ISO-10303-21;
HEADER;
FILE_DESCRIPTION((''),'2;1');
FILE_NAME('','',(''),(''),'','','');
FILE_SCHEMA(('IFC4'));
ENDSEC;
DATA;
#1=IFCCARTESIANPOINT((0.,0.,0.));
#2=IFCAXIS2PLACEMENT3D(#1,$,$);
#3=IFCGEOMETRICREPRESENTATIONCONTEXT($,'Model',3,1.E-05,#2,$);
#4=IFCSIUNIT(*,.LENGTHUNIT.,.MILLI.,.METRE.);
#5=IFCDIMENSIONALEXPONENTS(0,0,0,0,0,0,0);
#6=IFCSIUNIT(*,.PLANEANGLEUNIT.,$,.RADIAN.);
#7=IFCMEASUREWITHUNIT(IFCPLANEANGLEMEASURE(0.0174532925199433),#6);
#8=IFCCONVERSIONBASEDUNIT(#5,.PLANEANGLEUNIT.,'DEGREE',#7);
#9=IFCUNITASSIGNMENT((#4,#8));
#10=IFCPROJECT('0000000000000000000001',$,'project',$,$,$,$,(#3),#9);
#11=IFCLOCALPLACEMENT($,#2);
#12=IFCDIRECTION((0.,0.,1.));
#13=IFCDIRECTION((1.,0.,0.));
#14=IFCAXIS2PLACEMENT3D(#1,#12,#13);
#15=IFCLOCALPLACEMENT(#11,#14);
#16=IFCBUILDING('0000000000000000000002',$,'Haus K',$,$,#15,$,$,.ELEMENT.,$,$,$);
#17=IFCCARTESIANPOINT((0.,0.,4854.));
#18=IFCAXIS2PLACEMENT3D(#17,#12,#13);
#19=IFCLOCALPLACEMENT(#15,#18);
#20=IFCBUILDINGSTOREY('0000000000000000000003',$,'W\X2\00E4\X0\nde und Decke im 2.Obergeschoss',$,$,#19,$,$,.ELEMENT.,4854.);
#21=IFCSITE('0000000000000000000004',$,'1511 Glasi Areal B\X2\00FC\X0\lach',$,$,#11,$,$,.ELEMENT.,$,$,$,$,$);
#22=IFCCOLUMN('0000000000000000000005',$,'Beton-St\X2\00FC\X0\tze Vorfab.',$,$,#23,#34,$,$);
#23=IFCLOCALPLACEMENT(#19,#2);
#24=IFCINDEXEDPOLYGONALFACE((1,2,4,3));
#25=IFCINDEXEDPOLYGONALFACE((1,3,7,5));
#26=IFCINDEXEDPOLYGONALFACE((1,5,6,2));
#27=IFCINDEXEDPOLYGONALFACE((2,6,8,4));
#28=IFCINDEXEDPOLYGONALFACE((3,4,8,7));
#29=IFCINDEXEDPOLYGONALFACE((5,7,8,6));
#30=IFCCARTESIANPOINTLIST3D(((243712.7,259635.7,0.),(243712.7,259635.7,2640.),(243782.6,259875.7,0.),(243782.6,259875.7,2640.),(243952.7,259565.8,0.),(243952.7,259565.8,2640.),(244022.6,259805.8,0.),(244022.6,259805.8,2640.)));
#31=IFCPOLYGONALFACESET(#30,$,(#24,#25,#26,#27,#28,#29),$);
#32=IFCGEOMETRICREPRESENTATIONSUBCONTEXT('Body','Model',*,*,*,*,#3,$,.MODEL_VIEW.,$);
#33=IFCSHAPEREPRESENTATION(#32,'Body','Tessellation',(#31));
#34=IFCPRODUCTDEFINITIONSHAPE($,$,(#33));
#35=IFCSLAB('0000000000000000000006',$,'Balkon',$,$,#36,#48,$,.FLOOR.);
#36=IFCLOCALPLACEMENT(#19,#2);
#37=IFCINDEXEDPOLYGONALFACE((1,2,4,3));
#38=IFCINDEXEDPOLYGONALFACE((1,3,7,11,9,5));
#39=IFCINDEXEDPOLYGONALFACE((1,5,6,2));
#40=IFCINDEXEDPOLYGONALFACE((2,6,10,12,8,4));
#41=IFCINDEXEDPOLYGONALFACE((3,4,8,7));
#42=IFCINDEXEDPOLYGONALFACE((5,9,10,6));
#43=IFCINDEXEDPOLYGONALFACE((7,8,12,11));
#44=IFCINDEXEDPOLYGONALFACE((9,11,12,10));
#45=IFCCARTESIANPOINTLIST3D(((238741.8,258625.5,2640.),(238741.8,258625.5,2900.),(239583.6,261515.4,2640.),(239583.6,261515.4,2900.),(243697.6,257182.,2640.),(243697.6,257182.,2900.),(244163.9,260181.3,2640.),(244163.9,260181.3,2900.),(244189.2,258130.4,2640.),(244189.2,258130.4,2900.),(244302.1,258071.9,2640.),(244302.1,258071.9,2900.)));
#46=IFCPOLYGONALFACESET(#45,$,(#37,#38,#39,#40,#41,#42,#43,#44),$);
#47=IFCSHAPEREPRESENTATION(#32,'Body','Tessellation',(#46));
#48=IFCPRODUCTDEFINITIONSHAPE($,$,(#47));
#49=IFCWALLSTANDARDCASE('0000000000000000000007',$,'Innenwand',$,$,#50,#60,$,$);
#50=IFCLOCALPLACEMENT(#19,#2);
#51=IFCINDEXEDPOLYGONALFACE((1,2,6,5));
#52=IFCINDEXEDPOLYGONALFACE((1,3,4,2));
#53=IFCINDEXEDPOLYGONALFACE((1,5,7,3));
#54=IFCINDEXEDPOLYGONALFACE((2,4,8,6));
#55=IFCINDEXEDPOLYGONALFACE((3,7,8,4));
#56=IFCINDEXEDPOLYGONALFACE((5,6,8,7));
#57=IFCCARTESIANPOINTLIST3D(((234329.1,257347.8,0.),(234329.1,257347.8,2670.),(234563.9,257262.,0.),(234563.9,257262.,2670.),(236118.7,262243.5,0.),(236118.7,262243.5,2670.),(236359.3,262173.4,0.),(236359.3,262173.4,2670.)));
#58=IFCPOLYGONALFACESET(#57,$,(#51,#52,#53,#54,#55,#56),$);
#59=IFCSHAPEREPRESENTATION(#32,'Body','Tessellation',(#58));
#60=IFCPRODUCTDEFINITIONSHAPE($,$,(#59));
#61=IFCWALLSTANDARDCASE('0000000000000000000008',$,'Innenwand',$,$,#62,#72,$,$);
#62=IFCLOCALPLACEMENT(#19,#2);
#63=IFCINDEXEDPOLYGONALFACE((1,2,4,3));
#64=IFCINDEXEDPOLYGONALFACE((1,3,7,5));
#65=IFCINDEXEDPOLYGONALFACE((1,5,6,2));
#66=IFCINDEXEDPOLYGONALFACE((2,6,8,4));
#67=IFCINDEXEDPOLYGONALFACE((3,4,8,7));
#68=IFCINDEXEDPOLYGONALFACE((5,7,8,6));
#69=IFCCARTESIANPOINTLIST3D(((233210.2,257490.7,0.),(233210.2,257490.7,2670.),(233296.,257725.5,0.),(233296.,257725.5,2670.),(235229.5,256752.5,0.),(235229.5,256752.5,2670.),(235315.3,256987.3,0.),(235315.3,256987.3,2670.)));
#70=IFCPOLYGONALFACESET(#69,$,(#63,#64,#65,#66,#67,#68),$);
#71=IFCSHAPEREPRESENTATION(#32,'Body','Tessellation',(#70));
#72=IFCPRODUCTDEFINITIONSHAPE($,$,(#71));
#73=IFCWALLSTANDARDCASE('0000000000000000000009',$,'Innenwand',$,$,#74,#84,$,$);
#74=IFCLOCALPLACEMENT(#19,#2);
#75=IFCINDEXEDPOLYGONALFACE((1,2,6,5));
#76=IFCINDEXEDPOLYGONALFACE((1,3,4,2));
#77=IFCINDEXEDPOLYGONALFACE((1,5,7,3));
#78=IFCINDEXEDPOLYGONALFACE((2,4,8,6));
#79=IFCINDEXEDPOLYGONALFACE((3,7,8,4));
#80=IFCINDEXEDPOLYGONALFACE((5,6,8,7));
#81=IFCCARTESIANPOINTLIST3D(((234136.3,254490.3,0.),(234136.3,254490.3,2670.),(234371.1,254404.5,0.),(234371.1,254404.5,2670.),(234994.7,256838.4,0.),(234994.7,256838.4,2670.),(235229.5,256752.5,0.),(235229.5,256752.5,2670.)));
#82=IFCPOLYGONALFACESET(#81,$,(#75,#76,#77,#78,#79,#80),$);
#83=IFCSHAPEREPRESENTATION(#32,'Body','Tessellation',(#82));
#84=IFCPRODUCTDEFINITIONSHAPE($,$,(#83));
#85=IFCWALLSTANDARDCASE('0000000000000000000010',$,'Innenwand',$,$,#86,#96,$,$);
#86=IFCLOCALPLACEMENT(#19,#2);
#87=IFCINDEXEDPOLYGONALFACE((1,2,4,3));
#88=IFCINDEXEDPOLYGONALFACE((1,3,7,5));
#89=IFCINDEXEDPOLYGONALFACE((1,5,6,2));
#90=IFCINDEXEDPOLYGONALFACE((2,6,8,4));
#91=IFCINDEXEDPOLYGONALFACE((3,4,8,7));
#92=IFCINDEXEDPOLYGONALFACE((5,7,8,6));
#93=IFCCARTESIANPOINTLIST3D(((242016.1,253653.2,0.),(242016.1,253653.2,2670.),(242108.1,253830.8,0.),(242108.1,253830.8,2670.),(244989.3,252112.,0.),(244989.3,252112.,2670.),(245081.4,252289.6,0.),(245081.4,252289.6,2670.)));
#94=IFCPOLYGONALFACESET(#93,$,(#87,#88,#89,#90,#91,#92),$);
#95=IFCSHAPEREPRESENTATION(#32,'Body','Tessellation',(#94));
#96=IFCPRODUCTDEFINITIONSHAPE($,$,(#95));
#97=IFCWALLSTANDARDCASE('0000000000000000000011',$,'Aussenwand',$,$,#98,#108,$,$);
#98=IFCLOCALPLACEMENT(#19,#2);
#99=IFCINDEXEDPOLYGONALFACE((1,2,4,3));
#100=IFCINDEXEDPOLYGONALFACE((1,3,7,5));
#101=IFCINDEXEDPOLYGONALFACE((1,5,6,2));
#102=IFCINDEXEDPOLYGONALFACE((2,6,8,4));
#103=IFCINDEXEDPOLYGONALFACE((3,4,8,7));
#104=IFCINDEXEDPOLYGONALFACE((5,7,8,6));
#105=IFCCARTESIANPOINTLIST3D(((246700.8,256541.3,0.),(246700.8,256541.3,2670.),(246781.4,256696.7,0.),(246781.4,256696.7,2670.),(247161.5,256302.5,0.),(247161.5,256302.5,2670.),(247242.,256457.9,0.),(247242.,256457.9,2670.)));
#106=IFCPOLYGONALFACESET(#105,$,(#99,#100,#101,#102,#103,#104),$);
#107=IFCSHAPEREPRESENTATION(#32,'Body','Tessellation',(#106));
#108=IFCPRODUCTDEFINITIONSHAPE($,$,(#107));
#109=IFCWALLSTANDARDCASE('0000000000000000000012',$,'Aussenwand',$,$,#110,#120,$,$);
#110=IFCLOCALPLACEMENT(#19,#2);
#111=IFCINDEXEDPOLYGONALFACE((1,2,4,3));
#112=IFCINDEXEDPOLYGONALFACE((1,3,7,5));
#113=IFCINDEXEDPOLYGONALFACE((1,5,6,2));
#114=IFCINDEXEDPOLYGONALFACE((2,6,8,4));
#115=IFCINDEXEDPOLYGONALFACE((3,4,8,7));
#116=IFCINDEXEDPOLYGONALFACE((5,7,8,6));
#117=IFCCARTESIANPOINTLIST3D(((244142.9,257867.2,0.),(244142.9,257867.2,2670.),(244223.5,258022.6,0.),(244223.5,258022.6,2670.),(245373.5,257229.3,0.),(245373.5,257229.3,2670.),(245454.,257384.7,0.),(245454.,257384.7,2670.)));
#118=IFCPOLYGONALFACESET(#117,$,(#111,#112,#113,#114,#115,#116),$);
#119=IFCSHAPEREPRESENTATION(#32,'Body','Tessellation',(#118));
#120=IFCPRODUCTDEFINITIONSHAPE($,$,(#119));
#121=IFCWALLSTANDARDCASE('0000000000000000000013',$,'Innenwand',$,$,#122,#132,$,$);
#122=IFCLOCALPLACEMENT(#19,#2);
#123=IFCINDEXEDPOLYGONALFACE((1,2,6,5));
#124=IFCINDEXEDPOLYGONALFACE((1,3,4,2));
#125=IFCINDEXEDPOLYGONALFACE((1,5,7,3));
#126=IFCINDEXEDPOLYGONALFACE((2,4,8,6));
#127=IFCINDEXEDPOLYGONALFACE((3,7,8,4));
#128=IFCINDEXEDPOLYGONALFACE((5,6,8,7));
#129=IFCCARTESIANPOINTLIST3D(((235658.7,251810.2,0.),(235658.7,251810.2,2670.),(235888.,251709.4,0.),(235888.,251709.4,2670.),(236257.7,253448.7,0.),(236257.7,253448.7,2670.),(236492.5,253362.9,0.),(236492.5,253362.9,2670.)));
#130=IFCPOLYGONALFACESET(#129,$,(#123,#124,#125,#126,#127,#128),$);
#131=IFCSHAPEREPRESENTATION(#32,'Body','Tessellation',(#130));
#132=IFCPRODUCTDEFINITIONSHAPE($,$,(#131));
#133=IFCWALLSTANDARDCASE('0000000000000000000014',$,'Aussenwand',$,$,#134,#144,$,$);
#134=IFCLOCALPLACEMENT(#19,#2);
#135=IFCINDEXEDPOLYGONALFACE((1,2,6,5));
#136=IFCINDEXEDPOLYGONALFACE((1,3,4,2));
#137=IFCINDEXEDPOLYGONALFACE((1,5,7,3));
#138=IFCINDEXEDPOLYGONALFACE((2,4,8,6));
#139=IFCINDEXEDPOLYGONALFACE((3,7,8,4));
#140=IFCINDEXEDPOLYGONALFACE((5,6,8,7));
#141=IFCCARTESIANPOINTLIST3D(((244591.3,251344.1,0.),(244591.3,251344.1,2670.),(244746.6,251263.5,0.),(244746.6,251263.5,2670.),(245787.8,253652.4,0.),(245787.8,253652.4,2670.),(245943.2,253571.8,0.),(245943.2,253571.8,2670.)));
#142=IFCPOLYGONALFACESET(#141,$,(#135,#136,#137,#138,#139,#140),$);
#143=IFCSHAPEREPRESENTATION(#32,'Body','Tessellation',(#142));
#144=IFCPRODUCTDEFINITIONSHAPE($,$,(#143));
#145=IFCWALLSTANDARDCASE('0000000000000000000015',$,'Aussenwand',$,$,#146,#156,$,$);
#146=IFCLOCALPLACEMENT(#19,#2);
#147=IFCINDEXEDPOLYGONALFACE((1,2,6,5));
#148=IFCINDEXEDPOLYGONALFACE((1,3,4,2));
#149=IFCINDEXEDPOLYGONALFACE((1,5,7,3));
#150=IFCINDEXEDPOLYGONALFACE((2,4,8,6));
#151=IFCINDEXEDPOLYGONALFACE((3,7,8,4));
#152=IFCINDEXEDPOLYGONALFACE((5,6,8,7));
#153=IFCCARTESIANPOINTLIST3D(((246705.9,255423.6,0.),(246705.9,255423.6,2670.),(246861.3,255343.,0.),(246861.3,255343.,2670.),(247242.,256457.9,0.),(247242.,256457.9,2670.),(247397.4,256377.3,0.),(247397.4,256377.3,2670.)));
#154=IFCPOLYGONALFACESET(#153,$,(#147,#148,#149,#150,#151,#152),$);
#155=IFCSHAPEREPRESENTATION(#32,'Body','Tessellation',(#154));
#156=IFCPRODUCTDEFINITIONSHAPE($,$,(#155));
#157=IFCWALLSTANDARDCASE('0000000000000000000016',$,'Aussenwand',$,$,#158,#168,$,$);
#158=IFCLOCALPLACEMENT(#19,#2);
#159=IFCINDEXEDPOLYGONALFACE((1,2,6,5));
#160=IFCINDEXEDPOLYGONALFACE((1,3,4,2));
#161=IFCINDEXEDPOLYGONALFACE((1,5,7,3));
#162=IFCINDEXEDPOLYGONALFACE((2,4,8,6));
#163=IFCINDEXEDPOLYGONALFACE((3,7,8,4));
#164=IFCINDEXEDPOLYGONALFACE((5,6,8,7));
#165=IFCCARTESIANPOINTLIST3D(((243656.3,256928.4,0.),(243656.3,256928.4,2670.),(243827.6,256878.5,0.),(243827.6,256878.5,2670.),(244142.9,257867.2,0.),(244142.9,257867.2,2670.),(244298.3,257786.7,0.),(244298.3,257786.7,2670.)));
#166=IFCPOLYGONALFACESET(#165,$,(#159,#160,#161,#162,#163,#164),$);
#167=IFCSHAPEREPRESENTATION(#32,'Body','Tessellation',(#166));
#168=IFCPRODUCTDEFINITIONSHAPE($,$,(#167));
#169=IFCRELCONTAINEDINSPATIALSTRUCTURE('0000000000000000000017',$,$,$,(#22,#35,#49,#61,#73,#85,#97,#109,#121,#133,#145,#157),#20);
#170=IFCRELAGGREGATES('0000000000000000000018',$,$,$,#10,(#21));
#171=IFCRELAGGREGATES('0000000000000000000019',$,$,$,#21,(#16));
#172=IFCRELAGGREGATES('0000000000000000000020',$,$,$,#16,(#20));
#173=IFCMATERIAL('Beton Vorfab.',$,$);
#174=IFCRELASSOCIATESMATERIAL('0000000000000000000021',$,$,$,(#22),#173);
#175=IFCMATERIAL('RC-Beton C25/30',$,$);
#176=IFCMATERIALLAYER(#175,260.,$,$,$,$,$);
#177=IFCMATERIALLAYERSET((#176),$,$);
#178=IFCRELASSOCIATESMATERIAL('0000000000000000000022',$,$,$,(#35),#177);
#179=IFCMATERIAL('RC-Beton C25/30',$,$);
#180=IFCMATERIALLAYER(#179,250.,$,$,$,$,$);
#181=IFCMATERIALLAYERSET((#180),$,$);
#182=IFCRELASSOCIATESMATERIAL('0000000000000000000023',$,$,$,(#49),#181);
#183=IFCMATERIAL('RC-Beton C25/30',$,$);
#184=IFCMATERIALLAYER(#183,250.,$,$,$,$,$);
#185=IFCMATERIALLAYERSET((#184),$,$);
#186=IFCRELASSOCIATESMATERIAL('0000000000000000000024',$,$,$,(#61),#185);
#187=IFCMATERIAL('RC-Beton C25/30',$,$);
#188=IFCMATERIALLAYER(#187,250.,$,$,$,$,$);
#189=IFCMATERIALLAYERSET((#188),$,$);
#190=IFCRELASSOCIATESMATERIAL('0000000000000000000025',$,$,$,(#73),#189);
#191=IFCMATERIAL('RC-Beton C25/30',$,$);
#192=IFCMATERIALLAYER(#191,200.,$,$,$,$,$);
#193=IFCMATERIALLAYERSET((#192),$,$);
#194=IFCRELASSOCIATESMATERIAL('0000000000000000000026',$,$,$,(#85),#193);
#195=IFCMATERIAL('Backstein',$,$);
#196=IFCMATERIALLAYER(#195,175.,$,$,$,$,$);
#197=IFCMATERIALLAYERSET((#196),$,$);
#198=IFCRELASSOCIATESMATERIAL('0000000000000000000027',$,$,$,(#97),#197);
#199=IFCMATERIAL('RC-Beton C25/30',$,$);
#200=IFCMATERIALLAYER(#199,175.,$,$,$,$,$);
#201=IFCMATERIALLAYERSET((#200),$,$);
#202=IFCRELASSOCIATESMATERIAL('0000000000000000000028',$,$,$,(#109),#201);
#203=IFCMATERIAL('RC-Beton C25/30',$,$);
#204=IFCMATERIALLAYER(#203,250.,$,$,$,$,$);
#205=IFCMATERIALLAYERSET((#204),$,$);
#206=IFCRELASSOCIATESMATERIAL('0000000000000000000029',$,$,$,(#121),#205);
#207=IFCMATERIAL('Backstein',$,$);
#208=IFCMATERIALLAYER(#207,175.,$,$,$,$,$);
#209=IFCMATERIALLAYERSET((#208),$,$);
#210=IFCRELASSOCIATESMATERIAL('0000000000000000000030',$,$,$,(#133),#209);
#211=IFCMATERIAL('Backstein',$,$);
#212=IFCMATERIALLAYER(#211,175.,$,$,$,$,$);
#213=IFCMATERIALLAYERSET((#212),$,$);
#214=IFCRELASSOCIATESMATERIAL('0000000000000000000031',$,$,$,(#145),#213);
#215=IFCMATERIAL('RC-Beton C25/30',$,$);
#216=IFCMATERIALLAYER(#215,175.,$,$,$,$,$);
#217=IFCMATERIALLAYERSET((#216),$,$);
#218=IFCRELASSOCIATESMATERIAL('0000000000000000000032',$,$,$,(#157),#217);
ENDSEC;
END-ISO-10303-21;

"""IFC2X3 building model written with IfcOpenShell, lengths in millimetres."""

from ifc_helpers import new_model, entity, si_unit, converted_unit, frame, frame_2d, origin, origin_with_axes, place, context, subcontext, project, spatial, polyline, rectangle, outline, extrude, material, layer, layer_set, layer_usage, element, save


model = new_model("IFC2X3")

# Units and contexts
model_context = context("Model", 3, precision=1e-05, world=origin())
body_context = subcontext(model_context, "Body", "Model", "MODEL_VIEW")
ifc_project = project(units=[si_unit("LENGTHUNIT", "METRE", prefix="MILLI"), converted_unit("PLANEANGLEUNIT", "DEGREE", entity("IfcPlaneAngleMeasure", 0.0174532925199433), si_unit("PLANEANGLEUNIT", "RADIAN"), dimensions=[0, 0, 0, 0, 0, 0, 0])], contexts=[model_context])

# Site, building, storey
site_placement = place(None, origin())
site = spatial("IfcSite", under=ifc_project, at=site_placement, Name="1511 Glasi Areal Bülach", CompositionType="ELEMENT")
building_placement = place(site_placement, origin_with_axes())
building = spatial("IfcBuilding", under=site, at=building_placement, Name="Haus K", CompositionType="ELEMENT")
storey_placement = place(building_placement, frame((0.0, 0.0, 4854.0), z_axis=(0.0, 0.0, 1.0), x_axis=(1.0, 0.0, 0.0)))
storey = spatial("IfcBuildingStorey", under=building, at=storey_placement, Name="Wände und Decke im 2.Obergeschoss", CompositionType="ELEMENT", Elevation=4854.0)

# Column
ifc_material_1 = material(Name="Beton Vorfab.")
column_placement = place(storey_placement, frame((243712.7, 259635.7, 0.0), z_axis=(0.0, 0.0, 1.0), x_axis=(1.0, 0.0, 0.0)))
element("IfcColumn", 1, at=column_placement, inside=storey, material=ifc_material_1, Name="Beton-Stütze Vorfab.", context=body_context, shape_type="SweptSolid", body=[
    extrude(rectangle(XDim=250.0, YDim=250.0, at=frame_2d((155.0, 85.1), x_axis=(0.960099, -0.279661))), origin_with_axes(), (0.0, 0.0, 1.0), 2640.0),
])

# Slab
ifc_material_2 = material(Name="RC-Beton C25/30")
ifc_layer_1 = layer(ifc_material_2, 260.0)
ifc_layer_set_1 = layer_set([ifc_layer_1])
ifc_layer_usage_1 = layer_usage(ifc_layer_set_1, "AXIS3", "POSITIVE", 0.0)
slab_placement = place(storey_placement, frame((238741.8, 257182.0, 2640.0), z_axis=(0.0, 0.0, 1.0), x_axis=(1.0, 0.0, 0.0)))
element("IfcSlab", 2, at=slab_placement, inside=storey, material=ifc_layer_usage_1, Name="Balkon", PredefinedType="FLOOR", context=body_context, shape_type="SweptSolid", body=[
    extrude(outline(polyline([(841.8, 4333.4), (0.0, 1443.5), (4955.8, 0.0), (5447.4, 948.4), (5560.3, 889.9), (5422.0, 2999.3), (841.8, 4333.4)])), origin_with_axes(), (0.0, 0.0, 1.0), 260.0),
])

# Walls
ifc_material_3 = material(Name="RC-Beton C25/30")
ifc_layer_2 = layer(ifc_material_3, 250.0)
ifc_layer_set_2 = layer_set([ifc_layer_2])
ifc_layer_usage_2 = layer_usage(ifc_layer_set_2, "AXIS2", "POSITIVE", 0.0)
wall_1_placement = place(storey_placement, frame((234563.9, 257262.0, 0.0), z_axis=(0.0, 0.0, 1.0), x_axis=(0.343332, 0.939214, 0.0)))
element("IfcWallStandardCase", 3, at=wall_1_placement, inside=storey, material=ifc_layer_usage_2, Name="Innenwand", context=body_context, shape_type="SweptSolid", body=[
    extrude(outline(polyline([(0.0, 0.0), (5229.2, 0.0), (5212.5, 250.0), (0.0, 250.0), (0.0, 0.0)])), origin_with_axes(), (0.0, 0.0, 1.0), 2670.0),
])
ifc_material_4 = material(Name="RC-Beton C25/30")
ifc_layer_3 = layer(ifc_material_4, 250.0)
ifc_layer_set_3 = layer_set([ifc_layer_3])
ifc_layer_usage_3 = layer_usage(ifc_layer_set_3, "AXIS2", "POSITIVE", 0.0)
wall_2_placement = place(storey_placement, frame((235315.3, 256987.3, 0.0), z_axis=(0.0, 0.0, 1.0), x_axis=(-0.939214, 0.343332, 0.0)))
element("IfcWallStandardCase", 4, at=wall_2_placement, inside=storey, material=ifc_layer_usage_3, Name="Innenwand", context=body_context, shape_type="SweptSolid", body=[
    extrude(rectangle(XDim=2150.0, YDim=250.0, at=frame_2d((1075.0, 125.0), x_axis=(1.0, 0.0))), origin_with_axes(), (0.0, 0.0, 1.0), 2670.0),
])
ifc_material_5 = material(Name="RC-Beton C25/30")
ifc_layer_4 = layer(ifc_material_5, 250.0)
ifc_layer_set_4 = layer_set([ifc_layer_4])
ifc_layer_usage_4 = layer_usage(ifc_layer_set_4, "AXIS2", "POSITIVE", 0.0)
wall_3_placement = place(storey_placement, frame((234371.1, 254404.5, 0.0), z_axis=(0.0, 0.0, 1.0), x_axis=(0.343332, 0.939214, 0.0)))
element("IfcWallStandardCase", 5, at=wall_3_placement, inside=storey, material=ifc_layer_usage_4, Name="Innenwand", context=body_context, shape_type="SweptSolid", body=[
    extrude(rectangle(XDim=2500.0, YDim=250.0, at=frame_2d((1250.0, 125.0), x_axis=(1.0, 0.0))), origin_with_axes(), (0.0, 0.0, 1.0), 2670.0),
])
ifc_material_6 = material(Name="RC-Beton C25/30")
ifc_layer_5 = layer(ifc_material_6, 200.0)
ifc_layer_set_5 = layer_set([ifc_layer_5])
ifc_layer_usage_5 = layer_usage(ifc_layer_set_5, "AXIS2", "POSITIVE", 0.0)
wall_4_placement = place(storey_placement, frame((245081.4, 252289.6, 0.0), z_axis=(0.0, 0.0, 1.0), x_axis=(-0.887815, 0.4602, 0.0)))
element("IfcWallStandardCase", 6, at=wall_4_placement, inside=storey, material=ifc_layer_usage_5, Name="Innenwand", context=body_context, shape_type="SweptSolid", body=[
    extrude(rectangle(XDim=3349.0, YDim=200.0, at=frame_2d((1674.5, 100.0), x_axis=(1.0, 0.0))), origin_with_axes(), (0.0, 0.0, 1.0), 2670.0),
])
ifc_material_7 = material(Name="Backstein")
ifc_layer_6 = layer(ifc_material_7, 175.0)
ifc_layer_set_6 = layer_set([ifc_layer_6])
ifc_layer_usage_6 = layer_usage(ifc_layer_set_6, "AXIS2", "POSITIVE", 0.0)
wall_5_placement = place(storey_placement, frame((247242.0, 256457.9, 0.0), z_axis=(0.0, 0.0, 1.0), x_axis=(-0.887815, 0.4602, 0.0)))
element("IfcWallStandardCase", 7, at=wall_5_placement, inside=storey, material=ifc_layer_usage_6, Name="Aussenwand", context=body_context, shape_type="SweptSolid", body=[
    extrude(outline(polyline([(0.0, 0.0), (518.9, 0.0), (518.9, 175.0), (0.0, 175.0), (0.0, 0.0)])), origin_with_axes(), (0.0, 0.0, 1.0), 2670.0),
])
ifc_material_8 = material(Name="RC-Beton C25/30")
ifc_layer_7 = layer(ifc_material_8, 175.0)
ifc_layer_set_7 = layer_set([ifc_layer_7])
ifc_layer_usage_7 = layer_usage(ifc_layer_set_7, "AXIS2", "POSITIVE", 0.0)
wall_6_placement = place(storey_placement, frame((245454.0, 257384.7, 0.0), z_axis=(0.0, 0.0, 1.0), x_axis=(-0.887815, 0.4602, 0.0)))
element("IfcWallStandardCase", 8, at=wall_6_placement, inside=storey, material=ifc_layer_usage_7, Name="Aussenwand", context=body_context, shape_type="SweptSolid", body=[
    extrude(rectangle(XDim=1386.1, YDim=175.0, at=frame_2d((693.0, 87.5), x_axis=(1.0, 0.0))), origin_with_axes(), (0.0, 0.0, 1.0), 2670.0),
])
ifc_material_9 = material(Name="RC-Beton C25/30")
ifc_layer_8 = layer(ifc_material_9, 250.0)
ifc_layer_set_8 = layer_set([ifc_layer_8])
ifc_layer_usage_8 = layer_usage(ifc_layer_set_8, "AXIS2", "POSITIVE", 0.0)
wall_7_placement = place(storey_placement, frame((236257.7, 253448.7, 0.0), z_axis=(0.0, 0.0, 1.0), x_axis=(-0.343332, -0.939214, 0.0)))
element("IfcWallStandardCase", 9, at=wall_7_placement, inside=storey, material=ifc_layer_usage_8, Name="Innenwand", context=body_context, shape_type="SweptSolid", body=[
    extrude(outline(polyline([(0.0, 0.0), (1744.5, 0.0), (1760.5, 250.0), (0.0, 250.0), (0.0, 0.0)])), origin_with_axes(), (0.0, 0.0, 1.0), 2670.0),
])
ifc_material_10 = material(Name="Backstein")
ifc_layer_9 = layer(ifc_material_10, 175.0)
ifc_layer_set_9 = layer_set([ifc_layer_9])
ifc_layer_usage_9 = layer_usage(ifc_layer_set_9, "AXIS2", "POSITIVE", 0.0)
wall_8_placement = place(storey_placement, frame((244746.6, 251263.5, 0.0), z_axis=(0.0, 0.0, 1.0), x_axis=(0.4602, 0.887815, 0.0)))
element("IfcWallStandardCase", 10, at=wall_8_placement, inside=storey, material=ifc_layer_usage_9, Name="Aussenwand", context=body_context, shape_type="SweptSolid", body=[
    extrude(rectangle(XDim=2600.0, YDim=175.0, at=frame_2d((1300.0, 87.5), x_axis=(1.0, 0.0))), origin_with_axes(), (0.0, 0.0, 1.0), 2670.0),
])
ifc_material_11 = material(Name="Backstein")
ifc_layer_10 = layer(ifc_material_11, 175.0)
ifc_layer_set_10 = layer_set([ifc_layer_10])
ifc_layer_usage_10 = layer_usage(ifc_layer_set_10, "AXIS2", "POSITIVE", 0.0)
wall_9_placement = place(storey_placement, frame((246861.3, 255343.0, 0.0), z_axis=(0.0, 0.0, 1.0), x_axis=(0.4602, 0.887815, 0.0)))
element("IfcWallStandardCase", 11, at=wall_9_placement, inside=storey, material=ifc_layer_usage_10, Name="Aussenwand", context=body_context, shape_type="SweptSolid", body=[
    extrude(rectangle(XDim=1165.0, YDim=175.0, at=frame_2d((582.5, 87.5), x_axis=(1.0, 0.0))), origin_with_axes(), (0.0, 0.0, 1.0), 2670.0),
])
ifc_material_12 = material(Name="RC-Beton C25/30")
ifc_layer_11 = layer(ifc_material_12, 175.0)
ifc_layer_set_11 = layer_set([ifc_layer_11])
ifc_layer_usage_11 = layer_usage(ifc_layer_set_11, "AXIS2", "POSITIVE", 0.0)
wall_10_placement = place(storey_placement, frame((244142.9, 257867.2, 0.0), z_axis=(0.0, 0.0, 1.0), x_axis=(-0.4602, -0.887815, 0.0)))
element("IfcWallStandardCase", 12, at=wall_10_placement, inside=storey, material=ifc_layer_usage_11, Name="Aussenwand", context=body_context, shape_type="SweptSolid", body=[
    extrude(outline(polyline([(0.0, 0.0), (1057.4, 0.0), (1022.9, 175.0), (0.0, 175.0), (0.0, 0.0)])), origin_with_axes(), (0.0, 0.0, 1.0), 2670.0),
])

save(model, "model.ifc")
